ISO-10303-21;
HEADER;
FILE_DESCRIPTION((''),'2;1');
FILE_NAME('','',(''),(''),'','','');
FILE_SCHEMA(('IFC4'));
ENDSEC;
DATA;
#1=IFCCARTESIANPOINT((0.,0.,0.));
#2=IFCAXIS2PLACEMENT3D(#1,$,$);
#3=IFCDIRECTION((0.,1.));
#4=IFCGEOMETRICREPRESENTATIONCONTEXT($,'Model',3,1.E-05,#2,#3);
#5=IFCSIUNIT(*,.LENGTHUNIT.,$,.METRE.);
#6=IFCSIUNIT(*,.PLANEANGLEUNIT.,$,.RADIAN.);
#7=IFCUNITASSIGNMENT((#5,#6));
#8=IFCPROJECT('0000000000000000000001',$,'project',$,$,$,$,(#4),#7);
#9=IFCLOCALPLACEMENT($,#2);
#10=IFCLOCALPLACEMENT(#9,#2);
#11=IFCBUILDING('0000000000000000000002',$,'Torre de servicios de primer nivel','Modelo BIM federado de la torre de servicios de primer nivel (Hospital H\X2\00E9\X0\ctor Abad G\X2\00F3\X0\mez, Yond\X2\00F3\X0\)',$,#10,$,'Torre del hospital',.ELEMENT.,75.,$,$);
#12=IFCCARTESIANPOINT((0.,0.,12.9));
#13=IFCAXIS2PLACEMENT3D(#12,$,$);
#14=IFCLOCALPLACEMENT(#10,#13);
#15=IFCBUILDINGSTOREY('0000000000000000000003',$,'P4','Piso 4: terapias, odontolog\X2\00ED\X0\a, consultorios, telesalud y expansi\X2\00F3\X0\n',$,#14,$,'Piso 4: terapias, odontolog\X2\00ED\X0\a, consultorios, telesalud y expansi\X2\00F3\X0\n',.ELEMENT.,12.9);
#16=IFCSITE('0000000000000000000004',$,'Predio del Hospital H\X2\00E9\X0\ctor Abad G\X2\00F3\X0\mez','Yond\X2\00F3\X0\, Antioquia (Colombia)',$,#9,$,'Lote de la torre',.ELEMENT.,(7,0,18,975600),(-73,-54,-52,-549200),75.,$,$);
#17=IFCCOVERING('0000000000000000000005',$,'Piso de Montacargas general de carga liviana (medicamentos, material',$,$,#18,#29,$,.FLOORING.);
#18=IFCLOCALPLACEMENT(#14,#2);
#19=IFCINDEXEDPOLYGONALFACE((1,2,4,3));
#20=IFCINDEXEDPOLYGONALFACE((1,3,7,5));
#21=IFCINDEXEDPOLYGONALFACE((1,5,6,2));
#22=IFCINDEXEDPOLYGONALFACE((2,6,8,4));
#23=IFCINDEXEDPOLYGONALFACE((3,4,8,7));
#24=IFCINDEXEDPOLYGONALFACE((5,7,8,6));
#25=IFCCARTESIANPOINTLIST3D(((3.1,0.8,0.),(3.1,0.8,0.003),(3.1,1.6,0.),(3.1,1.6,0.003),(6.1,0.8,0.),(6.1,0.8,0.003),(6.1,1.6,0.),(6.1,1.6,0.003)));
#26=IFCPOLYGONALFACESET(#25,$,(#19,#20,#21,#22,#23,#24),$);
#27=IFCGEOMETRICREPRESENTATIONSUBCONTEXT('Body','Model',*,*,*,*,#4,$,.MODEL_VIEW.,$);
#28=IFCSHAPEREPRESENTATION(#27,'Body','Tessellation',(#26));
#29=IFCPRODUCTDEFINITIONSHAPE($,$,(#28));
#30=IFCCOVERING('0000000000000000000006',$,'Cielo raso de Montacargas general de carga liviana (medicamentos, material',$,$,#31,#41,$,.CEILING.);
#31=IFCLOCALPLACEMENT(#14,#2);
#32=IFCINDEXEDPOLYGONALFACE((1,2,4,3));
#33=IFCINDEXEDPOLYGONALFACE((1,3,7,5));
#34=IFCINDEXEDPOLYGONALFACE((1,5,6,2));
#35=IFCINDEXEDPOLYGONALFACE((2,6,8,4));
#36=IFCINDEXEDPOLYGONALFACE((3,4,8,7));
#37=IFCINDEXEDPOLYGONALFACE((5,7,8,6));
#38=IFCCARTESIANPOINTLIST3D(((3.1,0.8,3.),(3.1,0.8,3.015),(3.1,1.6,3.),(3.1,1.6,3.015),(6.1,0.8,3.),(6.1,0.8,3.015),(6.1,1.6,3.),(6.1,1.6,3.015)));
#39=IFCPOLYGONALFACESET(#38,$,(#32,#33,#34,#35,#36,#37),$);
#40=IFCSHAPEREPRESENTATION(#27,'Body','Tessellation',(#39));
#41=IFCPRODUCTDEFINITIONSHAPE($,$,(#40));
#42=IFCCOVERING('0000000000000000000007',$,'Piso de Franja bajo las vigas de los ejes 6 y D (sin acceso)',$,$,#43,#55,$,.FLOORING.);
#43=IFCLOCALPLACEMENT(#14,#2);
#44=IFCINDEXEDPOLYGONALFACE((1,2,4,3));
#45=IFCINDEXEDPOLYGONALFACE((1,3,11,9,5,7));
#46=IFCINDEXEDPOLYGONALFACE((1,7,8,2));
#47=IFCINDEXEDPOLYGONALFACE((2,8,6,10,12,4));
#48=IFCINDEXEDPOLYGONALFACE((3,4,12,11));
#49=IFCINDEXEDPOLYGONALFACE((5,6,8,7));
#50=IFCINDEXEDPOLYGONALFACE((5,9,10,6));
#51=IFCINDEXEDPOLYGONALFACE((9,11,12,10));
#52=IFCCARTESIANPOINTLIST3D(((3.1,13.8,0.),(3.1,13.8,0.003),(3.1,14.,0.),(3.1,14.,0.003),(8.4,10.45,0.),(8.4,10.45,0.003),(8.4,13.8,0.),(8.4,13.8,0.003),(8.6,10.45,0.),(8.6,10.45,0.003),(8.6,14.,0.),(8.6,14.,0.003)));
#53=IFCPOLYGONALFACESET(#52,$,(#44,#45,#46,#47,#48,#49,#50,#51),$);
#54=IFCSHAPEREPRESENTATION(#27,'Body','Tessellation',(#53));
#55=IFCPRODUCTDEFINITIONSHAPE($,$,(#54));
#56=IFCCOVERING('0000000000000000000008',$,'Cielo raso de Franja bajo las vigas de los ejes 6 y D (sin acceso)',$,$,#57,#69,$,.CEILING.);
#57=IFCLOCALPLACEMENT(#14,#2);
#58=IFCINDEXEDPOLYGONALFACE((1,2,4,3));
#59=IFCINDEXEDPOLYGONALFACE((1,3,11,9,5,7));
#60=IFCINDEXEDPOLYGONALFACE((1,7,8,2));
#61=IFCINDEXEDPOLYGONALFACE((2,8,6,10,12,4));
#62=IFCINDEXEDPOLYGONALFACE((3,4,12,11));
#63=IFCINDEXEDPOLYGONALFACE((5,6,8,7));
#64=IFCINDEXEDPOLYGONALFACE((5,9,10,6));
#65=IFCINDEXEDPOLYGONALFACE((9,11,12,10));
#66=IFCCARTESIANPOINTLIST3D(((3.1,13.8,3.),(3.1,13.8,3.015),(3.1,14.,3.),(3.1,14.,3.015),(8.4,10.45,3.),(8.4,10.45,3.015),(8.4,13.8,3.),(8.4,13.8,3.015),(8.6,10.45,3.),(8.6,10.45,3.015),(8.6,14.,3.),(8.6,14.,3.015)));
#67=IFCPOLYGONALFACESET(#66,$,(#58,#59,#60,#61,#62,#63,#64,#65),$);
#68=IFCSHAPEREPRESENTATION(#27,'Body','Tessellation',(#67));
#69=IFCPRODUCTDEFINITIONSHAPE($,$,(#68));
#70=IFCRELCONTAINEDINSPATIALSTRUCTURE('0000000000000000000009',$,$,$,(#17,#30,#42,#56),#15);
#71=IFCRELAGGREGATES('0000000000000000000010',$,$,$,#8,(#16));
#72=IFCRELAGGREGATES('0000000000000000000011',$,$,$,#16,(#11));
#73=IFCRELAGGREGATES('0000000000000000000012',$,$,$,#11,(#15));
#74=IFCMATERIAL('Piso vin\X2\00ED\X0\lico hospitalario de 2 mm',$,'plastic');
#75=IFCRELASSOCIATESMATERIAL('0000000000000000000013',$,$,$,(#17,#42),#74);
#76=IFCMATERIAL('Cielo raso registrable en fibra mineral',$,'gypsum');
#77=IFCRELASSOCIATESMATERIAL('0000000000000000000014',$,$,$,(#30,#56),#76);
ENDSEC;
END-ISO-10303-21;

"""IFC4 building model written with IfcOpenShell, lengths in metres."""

from ifc_helpers import new_model, si_unit, direction, frame, origin, place, context, subcontext, project, spatial, indexed_curve, outline, extrude, material, element, save


model = new_model("IFC4")

# Units and contexts
model_context = context("Model", 3, precision=1e-05, world=origin(), true_north=direction((0.0, 1.0)))
body_context = subcontext(model_context, "Body", "Model", "MODEL_VIEW")
ifc_project = project(units=[si_unit("LENGTHUNIT", "METRE"), si_unit("PLANEANGLEUNIT", "RADIAN")], contexts=[model_context])

# Site, building, storey
site_placement = place(None, origin())
site = spatial("IfcSite", under=ifc_project, at=site_placement, Name="Predio del Hospital Héctor Abad Gómez", Description="Yondó, Antioquia (Colombia)", LongName="Lote de la torre", CompositionType="ELEMENT", RefLatitude=(7, 0, 18, 975600), RefLongitude=(-73, -54, -52, -549200), RefElevation=75.0)
building_placement = place(site_placement, origin())
building = spatial("IfcBuilding", under=site, at=building_placement, Name="Torre de servicios de primer nivel", Description="Modelo BIM federado de la torre de servicios de primer nivel (Hospital Héctor Abad Gómez, Yondó)", LongName="Torre del hospital", CompositionType="ELEMENT", ElevationOfRefHeight=75.0)
placement = place(building_placement, frame((0.0, 0.0, 12.9)))
storey = spatial("IfcBuildingStorey", under=building, at=placement, Name="P4", Description="Piso 4: terapias, odontología, consultorios, telesalud y expansión", LongName="Piso 4: terapias, odontología, consultorios, telesalud y expansión", CompositionType="ELEMENT", Elevation=12.9)

# Coverings
ifc_material_1 = material(Name="Piso vinílico hospitalario de 2 mm", Category="plastic")
element("IfcCovering", 1, at=placement, inside=storey, material=ifc_material_1, Name="Piso de Montacargas general de carga liviana (medicamentos, material", PredefinedType="FLOORING", context=body_context, shape_type="SweptSolid", body=[
    extrude(outline(indexed_curve([(3.1, 0.8), (6.1, 0.8), (6.1, 1.6), (3.1, 1.6), (3.1, 0.8)], self_intersect=False)), origin(), (0.0, 0.0, 1.0), 0.003),
])
ifc_material_2 = material(Name="Cielo raso registrable en fibra mineral", Category="gypsum")
element("IfcCovering", 2, at=placement, inside=storey, material=ifc_material_2, Name="Cielo raso de Montacargas general de carga liviana (medicamentos, material", PredefinedType="CEILING", context=body_context, shape_type="SweptSolid", body=[
    extrude(outline(indexed_curve([(3.1, 0.8), (6.1, 0.8), (6.1, 1.6), (3.1, 1.6), (3.1, 0.8)], self_intersect=False)), frame((0.0, 0.0, 3.0)), (0.0, 0.0, 1.0), 0.015),
])
element("IfcCovering", 3, at=placement, inside=storey, material=ifc_material_1, Name="Piso de Franja bajo las vigas de los ejes 6 y D (sin acceso)", PredefinedType="FLOORING", context=body_context, shape_type="SweptSolid", body=[
    extrude(outline(indexed_curve([(3.1, 13.8), (8.4, 13.8), (8.4, 10.45), (8.6, 10.45), (8.6, 14.0), (3.1, 14.0), (3.1, 13.8)], self_intersect=False)), origin(), (0.0, 0.0, 1.0), 0.003),
])
element("IfcCovering", 4, at=placement, inside=storey, material=ifc_material_2, Name="Cielo raso de Franja bajo las vigas de los ejes 6 y D (sin acceso)", PredefinedType="CEILING", context=body_context, shape_type="SweptSolid", body=[
    extrude(outline(indexed_curve([(3.1, 13.8), (8.4, 13.8), (8.4, 10.45), (8.6, 10.45), (8.6, 14.0), (3.1, 14.0), (3.1, 13.8)], self_intersect=False)), frame((0.0, 0.0, 3.0)), (0.0, 0.0, 1.0), 0.015),
])

save(model, "model.ifc")
